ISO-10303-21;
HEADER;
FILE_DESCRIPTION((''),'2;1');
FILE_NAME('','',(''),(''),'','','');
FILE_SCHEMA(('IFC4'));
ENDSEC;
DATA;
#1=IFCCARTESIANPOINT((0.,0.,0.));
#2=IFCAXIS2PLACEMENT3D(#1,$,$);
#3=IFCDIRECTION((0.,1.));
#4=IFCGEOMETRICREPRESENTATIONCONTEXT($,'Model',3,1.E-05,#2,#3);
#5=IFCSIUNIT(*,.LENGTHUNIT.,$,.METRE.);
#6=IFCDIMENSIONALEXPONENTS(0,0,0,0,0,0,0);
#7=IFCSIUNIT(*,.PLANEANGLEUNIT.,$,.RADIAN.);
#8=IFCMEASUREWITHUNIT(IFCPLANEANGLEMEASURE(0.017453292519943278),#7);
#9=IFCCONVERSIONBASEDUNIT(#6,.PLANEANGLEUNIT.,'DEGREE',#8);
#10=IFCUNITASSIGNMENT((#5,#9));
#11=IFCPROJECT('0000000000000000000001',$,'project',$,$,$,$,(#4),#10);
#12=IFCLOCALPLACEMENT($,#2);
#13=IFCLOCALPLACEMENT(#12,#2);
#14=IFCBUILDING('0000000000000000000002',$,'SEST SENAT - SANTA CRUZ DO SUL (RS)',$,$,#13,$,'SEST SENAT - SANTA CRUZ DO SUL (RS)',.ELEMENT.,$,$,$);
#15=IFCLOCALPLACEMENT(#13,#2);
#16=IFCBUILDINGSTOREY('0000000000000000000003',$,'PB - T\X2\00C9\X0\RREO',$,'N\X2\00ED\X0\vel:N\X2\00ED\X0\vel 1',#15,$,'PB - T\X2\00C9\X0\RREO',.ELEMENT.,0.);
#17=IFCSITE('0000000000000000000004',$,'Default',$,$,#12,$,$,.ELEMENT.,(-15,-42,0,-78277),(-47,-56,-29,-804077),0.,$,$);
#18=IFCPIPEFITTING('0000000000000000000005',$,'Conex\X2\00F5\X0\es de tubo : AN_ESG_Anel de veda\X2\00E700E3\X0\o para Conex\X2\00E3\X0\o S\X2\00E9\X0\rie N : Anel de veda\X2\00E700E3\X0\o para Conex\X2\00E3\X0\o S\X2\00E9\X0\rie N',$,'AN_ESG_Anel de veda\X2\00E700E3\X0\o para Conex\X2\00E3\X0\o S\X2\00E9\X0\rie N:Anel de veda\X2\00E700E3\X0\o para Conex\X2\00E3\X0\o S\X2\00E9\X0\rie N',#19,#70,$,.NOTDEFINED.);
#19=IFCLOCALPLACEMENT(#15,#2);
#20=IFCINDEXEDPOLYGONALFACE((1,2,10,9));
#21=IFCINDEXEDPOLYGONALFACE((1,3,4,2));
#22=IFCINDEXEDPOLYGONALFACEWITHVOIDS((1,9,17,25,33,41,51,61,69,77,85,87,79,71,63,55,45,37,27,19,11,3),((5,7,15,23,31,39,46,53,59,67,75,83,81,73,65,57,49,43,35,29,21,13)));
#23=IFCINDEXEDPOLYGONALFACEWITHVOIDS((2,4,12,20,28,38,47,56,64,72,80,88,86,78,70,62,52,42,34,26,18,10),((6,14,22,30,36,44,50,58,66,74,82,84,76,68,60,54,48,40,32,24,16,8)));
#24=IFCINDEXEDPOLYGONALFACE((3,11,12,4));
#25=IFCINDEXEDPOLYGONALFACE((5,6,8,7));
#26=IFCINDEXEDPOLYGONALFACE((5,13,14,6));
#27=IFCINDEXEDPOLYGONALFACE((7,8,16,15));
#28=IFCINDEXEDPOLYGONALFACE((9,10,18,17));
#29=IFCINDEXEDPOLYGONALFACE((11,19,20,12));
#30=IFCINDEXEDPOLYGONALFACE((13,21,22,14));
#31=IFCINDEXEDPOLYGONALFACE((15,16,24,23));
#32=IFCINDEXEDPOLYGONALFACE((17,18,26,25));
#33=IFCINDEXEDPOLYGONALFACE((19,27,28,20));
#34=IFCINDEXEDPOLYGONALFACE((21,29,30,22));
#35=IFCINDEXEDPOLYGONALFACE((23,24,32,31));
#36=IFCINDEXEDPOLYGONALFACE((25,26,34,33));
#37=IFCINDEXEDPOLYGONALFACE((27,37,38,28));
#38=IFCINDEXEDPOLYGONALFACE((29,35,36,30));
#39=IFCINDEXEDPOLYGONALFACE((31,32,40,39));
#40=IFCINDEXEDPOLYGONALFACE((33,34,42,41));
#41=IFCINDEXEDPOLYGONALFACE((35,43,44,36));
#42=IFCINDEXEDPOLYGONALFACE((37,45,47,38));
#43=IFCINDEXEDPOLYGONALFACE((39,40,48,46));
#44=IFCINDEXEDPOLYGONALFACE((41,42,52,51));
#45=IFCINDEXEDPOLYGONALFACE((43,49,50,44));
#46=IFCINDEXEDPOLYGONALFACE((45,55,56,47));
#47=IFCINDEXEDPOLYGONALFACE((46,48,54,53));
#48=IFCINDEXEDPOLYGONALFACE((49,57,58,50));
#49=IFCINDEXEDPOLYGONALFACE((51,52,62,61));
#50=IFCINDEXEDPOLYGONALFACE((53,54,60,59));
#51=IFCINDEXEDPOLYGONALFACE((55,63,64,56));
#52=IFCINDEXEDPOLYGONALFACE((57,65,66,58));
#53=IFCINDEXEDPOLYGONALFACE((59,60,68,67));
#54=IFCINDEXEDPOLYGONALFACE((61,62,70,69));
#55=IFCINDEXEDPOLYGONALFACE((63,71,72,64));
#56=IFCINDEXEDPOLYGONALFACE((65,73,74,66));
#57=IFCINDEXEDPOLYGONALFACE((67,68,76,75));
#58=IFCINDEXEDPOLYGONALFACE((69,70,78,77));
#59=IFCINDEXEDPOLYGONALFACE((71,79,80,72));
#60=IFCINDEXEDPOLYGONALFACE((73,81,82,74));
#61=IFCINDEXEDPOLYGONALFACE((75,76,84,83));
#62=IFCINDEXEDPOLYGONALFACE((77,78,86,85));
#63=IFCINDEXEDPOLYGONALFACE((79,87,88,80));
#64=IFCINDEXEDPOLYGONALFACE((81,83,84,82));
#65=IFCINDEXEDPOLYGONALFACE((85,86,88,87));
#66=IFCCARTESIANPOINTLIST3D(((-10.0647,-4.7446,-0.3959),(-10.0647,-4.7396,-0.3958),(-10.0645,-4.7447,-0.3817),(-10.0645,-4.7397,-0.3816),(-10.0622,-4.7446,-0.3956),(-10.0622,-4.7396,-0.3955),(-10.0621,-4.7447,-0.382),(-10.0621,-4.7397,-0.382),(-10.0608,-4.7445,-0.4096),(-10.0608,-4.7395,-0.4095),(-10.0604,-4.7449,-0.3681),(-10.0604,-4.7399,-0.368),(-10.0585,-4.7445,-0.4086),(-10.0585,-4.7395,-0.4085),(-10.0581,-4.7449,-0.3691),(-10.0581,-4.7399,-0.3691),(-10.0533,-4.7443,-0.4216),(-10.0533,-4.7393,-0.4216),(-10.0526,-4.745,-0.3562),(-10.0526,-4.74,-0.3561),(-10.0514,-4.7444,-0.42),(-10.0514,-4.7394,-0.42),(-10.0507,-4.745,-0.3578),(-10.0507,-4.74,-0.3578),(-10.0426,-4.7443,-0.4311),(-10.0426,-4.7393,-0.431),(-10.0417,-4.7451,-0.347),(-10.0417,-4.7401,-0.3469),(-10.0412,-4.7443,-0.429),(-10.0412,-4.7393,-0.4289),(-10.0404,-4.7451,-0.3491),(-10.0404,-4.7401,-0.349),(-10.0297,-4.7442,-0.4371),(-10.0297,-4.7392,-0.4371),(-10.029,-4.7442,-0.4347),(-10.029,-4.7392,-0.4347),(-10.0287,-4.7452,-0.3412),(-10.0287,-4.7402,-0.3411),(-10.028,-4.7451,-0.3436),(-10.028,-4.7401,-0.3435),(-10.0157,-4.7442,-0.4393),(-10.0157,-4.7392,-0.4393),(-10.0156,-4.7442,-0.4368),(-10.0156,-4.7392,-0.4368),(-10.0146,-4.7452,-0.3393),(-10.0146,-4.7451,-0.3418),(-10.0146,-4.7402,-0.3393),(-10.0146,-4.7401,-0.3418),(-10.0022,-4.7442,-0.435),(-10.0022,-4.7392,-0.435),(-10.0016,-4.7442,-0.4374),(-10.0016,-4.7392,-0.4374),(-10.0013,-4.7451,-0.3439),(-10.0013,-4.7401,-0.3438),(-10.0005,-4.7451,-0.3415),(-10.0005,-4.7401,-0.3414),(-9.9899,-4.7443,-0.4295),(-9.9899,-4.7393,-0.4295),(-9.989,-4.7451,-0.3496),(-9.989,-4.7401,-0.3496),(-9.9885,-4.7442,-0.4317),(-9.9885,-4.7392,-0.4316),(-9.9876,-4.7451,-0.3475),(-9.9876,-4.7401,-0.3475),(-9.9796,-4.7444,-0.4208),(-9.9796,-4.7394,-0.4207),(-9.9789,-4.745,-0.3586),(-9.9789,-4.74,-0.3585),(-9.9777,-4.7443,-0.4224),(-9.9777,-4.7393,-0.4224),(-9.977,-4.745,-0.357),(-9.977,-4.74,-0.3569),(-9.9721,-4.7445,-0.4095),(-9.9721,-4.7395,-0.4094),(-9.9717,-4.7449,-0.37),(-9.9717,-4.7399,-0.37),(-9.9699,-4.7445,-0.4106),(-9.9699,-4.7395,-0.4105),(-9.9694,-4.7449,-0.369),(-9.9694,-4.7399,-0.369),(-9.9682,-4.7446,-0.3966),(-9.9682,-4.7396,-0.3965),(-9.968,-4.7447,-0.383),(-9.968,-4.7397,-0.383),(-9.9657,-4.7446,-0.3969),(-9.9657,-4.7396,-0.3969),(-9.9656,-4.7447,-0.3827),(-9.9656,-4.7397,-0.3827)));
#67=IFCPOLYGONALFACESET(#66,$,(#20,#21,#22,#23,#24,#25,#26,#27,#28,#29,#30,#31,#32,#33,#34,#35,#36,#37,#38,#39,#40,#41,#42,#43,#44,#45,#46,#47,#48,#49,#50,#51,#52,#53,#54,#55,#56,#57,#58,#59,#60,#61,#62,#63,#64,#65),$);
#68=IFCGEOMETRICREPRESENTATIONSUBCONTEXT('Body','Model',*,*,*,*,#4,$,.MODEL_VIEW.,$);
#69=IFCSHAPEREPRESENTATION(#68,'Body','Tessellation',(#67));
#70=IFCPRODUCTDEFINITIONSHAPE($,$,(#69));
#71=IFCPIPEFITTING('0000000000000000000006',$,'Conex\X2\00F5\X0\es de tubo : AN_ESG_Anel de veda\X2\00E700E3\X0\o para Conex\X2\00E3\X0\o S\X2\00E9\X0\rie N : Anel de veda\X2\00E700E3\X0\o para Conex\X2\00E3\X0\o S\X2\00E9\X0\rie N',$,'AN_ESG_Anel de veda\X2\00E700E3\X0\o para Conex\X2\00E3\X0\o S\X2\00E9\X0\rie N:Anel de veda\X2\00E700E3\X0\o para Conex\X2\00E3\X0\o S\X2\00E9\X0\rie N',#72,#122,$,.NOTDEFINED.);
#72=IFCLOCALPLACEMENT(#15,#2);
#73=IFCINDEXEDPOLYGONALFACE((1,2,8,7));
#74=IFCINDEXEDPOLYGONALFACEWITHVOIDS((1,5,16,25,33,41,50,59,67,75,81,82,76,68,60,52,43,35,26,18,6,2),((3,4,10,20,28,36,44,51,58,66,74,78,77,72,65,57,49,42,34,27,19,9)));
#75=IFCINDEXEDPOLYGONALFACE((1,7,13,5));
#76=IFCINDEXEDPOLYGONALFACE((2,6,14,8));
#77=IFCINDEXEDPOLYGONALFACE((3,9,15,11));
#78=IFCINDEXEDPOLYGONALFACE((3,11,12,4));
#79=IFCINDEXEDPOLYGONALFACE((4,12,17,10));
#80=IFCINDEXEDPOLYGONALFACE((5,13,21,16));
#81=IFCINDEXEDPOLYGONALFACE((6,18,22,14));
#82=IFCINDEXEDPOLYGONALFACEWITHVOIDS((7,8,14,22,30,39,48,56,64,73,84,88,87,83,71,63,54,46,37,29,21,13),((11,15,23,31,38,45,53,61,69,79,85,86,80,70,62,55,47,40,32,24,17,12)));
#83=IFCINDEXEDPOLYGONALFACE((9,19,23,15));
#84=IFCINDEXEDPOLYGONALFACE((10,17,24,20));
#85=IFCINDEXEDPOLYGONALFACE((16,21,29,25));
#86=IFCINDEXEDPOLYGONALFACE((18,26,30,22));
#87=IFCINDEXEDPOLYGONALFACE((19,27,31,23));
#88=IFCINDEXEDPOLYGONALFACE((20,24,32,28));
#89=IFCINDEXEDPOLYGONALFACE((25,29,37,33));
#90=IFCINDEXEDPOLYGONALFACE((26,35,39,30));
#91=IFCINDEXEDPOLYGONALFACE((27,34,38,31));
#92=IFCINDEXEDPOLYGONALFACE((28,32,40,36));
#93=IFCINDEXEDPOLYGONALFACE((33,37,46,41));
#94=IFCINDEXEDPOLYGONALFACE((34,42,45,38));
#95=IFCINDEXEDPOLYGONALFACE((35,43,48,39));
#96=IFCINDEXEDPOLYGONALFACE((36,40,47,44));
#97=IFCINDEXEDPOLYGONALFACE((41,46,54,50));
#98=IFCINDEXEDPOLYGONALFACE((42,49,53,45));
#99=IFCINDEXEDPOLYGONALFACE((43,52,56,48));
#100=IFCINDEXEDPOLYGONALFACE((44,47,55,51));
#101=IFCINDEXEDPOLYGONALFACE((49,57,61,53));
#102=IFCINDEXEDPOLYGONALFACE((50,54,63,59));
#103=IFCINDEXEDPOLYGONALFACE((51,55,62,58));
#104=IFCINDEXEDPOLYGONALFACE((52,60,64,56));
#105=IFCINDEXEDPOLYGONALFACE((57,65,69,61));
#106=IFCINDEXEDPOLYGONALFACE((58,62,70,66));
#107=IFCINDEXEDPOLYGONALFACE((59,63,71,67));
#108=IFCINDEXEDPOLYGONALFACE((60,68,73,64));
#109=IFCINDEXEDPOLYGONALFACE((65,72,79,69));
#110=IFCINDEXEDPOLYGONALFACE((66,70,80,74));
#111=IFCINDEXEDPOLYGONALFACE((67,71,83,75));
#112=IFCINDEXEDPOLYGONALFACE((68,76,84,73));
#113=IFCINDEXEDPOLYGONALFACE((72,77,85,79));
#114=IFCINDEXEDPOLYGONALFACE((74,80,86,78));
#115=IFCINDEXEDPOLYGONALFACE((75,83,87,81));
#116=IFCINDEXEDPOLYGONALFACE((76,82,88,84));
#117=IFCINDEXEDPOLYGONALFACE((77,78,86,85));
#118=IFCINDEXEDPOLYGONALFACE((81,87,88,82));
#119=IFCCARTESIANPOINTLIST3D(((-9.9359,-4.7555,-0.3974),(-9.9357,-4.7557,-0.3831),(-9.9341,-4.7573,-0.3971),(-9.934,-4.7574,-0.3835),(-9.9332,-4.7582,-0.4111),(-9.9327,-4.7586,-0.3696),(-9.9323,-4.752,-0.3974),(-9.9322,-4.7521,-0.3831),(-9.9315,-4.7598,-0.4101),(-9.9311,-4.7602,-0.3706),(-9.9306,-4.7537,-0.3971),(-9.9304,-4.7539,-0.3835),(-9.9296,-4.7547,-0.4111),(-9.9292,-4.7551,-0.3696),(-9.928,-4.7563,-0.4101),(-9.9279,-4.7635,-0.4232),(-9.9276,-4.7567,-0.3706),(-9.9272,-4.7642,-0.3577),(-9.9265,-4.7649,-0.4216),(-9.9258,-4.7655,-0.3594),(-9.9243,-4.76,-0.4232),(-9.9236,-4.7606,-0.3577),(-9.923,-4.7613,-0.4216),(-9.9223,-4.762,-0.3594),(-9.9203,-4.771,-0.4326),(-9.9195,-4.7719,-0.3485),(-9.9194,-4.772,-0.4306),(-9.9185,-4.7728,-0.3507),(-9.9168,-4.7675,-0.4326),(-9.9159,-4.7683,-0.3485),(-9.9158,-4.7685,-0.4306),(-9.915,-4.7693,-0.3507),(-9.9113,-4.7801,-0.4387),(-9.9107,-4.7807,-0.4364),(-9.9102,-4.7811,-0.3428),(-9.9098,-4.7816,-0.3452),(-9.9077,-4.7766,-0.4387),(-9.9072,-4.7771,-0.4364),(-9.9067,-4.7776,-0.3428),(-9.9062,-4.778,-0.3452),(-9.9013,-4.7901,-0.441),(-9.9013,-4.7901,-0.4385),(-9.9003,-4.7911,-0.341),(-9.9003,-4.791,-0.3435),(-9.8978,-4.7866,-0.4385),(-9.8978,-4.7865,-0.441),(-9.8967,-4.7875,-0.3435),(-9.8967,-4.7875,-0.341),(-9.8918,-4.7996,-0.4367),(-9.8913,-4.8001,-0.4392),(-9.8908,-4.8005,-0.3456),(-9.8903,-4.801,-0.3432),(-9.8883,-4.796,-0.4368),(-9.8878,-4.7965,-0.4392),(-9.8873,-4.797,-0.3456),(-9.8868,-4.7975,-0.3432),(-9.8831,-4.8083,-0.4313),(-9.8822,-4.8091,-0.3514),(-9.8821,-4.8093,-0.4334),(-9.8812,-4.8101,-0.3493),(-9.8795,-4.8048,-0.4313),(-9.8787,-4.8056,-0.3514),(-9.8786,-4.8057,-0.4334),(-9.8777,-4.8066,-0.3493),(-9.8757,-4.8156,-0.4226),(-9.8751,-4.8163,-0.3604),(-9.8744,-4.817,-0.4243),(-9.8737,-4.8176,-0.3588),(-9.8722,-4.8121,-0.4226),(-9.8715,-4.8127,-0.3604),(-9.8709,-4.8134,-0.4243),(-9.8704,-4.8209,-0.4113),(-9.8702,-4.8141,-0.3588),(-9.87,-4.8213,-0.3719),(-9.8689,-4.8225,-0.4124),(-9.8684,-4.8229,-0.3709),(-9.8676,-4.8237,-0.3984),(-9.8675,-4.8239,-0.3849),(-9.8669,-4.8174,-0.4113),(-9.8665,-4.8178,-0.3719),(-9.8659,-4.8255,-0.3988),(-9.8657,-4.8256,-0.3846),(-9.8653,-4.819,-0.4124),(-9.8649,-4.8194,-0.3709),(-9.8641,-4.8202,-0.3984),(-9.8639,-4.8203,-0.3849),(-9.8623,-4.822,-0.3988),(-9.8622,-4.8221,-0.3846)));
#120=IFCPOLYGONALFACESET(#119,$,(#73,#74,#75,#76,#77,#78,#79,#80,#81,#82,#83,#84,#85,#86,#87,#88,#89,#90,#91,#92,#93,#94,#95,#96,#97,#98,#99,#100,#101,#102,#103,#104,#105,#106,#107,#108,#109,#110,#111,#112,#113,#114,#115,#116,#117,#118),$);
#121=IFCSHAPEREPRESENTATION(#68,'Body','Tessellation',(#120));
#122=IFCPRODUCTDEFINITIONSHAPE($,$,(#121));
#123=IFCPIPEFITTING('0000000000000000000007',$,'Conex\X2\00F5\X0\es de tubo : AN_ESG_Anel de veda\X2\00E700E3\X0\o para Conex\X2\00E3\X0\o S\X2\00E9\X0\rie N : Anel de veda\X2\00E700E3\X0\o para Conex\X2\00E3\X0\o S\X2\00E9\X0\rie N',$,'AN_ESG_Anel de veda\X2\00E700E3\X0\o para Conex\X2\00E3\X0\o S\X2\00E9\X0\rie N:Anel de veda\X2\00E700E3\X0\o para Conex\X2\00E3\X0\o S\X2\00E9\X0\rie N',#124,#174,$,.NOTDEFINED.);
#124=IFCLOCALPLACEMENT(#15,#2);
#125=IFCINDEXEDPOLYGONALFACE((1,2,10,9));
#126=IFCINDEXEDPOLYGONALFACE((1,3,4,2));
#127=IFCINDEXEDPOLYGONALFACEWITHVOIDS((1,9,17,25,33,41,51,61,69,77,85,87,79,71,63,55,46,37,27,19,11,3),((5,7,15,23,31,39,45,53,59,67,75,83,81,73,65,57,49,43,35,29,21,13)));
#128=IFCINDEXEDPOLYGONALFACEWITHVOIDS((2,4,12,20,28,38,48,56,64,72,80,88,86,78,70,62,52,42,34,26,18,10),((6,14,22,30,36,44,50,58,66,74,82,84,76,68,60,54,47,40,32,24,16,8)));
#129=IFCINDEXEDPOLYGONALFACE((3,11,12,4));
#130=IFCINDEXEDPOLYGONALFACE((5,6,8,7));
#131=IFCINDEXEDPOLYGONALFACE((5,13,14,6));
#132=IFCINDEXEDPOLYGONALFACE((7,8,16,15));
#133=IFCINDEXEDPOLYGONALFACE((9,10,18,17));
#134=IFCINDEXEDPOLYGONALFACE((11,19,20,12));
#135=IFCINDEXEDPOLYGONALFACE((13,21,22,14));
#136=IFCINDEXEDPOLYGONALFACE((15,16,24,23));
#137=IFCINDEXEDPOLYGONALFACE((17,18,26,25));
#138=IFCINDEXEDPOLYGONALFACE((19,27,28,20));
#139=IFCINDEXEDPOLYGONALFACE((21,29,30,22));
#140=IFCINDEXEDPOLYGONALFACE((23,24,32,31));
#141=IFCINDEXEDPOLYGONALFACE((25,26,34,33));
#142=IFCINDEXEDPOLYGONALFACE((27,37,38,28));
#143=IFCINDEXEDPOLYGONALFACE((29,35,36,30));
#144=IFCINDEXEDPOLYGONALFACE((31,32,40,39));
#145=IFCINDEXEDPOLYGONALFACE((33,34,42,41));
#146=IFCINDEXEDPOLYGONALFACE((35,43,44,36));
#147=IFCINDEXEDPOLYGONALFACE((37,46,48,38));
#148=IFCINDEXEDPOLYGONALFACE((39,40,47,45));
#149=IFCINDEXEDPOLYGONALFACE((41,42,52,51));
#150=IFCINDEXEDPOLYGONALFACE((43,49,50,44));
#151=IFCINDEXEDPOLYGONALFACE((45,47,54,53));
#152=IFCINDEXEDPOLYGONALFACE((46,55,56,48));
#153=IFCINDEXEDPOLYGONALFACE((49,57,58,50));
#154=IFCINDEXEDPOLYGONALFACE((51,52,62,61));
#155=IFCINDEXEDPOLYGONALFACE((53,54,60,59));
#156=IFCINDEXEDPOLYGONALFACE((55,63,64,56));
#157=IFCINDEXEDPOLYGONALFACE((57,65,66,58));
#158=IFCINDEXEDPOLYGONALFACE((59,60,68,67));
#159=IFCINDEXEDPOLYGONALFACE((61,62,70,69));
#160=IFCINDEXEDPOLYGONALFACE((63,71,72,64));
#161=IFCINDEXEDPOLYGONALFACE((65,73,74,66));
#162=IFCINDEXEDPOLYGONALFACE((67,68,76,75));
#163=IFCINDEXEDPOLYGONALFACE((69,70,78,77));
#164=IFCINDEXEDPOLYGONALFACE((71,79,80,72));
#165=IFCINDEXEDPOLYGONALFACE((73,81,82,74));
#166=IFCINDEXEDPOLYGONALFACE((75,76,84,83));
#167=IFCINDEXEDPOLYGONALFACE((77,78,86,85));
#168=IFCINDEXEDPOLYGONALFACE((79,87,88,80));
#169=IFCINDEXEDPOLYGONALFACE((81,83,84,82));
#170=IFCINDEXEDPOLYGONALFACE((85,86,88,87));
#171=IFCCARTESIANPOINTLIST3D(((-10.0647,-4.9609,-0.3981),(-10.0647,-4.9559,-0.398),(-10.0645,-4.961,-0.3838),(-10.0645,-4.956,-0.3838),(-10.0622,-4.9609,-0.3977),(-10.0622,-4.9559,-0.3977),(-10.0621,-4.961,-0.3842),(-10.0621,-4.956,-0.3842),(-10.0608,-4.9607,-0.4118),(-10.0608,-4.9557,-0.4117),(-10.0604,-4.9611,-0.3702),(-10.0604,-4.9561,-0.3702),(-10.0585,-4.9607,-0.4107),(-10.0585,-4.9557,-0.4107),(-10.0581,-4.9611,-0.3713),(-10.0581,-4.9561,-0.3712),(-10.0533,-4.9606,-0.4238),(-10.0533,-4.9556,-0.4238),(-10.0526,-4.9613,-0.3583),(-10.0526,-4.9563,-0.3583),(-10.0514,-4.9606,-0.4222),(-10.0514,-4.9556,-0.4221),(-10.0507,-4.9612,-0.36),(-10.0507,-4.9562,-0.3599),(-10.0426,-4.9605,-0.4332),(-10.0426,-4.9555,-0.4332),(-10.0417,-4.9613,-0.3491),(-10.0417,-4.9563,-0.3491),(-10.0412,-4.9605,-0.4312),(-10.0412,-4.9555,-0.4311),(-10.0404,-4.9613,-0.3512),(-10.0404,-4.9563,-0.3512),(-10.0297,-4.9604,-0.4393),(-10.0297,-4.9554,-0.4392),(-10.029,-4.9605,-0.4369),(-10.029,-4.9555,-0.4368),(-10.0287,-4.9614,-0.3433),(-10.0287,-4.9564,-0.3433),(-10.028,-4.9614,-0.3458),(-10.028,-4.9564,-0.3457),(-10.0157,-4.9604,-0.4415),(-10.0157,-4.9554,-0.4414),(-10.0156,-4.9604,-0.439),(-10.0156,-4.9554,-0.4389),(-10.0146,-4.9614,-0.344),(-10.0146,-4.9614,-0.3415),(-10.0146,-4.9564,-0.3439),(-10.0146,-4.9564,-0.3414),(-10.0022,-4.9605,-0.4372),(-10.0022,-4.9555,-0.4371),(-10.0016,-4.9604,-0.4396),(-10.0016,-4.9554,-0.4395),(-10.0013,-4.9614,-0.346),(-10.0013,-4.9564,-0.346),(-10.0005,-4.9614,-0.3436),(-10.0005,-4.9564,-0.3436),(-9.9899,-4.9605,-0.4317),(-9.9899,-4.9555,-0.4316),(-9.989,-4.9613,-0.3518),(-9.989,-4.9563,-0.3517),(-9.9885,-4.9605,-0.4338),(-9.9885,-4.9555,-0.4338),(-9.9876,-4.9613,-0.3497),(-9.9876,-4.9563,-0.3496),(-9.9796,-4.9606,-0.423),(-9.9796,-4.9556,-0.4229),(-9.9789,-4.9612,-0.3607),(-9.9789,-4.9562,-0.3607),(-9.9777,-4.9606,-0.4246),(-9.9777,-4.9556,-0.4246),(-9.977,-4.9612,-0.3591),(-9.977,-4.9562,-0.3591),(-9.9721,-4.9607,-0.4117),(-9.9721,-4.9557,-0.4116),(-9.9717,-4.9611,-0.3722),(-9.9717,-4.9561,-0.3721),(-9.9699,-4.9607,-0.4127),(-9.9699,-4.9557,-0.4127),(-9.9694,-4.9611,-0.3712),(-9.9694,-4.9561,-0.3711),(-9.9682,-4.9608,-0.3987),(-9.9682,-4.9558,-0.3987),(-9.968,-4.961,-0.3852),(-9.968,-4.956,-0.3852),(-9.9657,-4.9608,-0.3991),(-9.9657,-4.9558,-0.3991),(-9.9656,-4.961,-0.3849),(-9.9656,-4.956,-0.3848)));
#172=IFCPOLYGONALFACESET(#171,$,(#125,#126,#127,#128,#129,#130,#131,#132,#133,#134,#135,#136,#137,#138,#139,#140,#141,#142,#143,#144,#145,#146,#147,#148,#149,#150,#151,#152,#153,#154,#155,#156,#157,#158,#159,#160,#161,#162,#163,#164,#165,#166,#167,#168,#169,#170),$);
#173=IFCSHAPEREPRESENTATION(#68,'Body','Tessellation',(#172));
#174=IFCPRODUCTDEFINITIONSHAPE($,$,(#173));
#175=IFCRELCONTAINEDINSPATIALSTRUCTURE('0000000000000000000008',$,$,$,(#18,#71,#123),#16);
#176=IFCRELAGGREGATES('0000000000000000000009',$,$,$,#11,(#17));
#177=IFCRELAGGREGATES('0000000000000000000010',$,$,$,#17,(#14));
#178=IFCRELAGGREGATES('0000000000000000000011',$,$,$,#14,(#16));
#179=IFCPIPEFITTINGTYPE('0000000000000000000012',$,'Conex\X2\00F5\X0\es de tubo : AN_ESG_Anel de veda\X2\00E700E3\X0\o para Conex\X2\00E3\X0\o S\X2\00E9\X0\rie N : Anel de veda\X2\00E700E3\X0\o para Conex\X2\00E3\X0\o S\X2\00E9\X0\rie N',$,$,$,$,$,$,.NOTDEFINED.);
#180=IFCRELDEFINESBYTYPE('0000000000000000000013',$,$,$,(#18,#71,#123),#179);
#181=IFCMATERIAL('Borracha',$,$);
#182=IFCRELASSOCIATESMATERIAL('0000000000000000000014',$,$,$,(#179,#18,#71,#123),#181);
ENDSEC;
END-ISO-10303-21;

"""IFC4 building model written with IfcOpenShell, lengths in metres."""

from ifc_helpers import new_model, entity, si_unit, converted_unit, direction, frame, origin, place, context, subcontext, project, spatial, arc, indexed_curve, outline, extrude, source, transform, mapped, material, type_object, type_shapes, element, save


model = new_model("IFC4")

# Units and contexts
model_context = context("Model", 3, precision=1e-05, world=origin(), true_north=direction((0.0, 1.0)))
body_context = subcontext(model_context, "Body", "Model", "MODEL_VIEW")
ifc_project = project(units=[si_unit("LENGTHUNIT", "METRE"), converted_unit("PLANEANGLEUNIT", "DEGREE", entity("IfcPlaneAngleMeasure", 0.017453292519943278), si_unit("PLANEANGLEUNIT", "RADIAN"), dimensions=[0, 0, 0, 0, 0, 0, 0])], contexts=[model_context])

# Site, building, storey
site_placement = place(None, origin())
site = spatial("IfcSite", under=ifc_project, at=site_placement, Name="Default", CompositionType="ELEMENT", RefLatitude=(-15, -42, 0, -78277), RefLongitude=(-47, -56, -29, -804077), RefElevation=0.0)
building_placement = place(site_placement, origin())
building = spatial("IfcBuilding", under=site, at=building_placement, Name="SEST SENAT - SANTA CRUZ DO SUL (RS)", LongName="SEST SENAT - SANTA CRUZ DO SUL (RS)", CompositionType="ELEMENT")
storey_placement = place(building_placement, origin())
storey = spatial("IfcBuildingStorey", under=building, at=storey_placement, Name="PB - TÉRREO", ObjectType="Nível:Nível 1", LongName="PB - TÉRREO", CompositionType="ELEMENT", Elevation=0.0)

# Pipe fittings
ifc_material_1 = material(Name="Borracha")
pipe_fitting_type_1 = type_object("IfcPipeFittingType", Name="Conexões de tubo : AN_ESG_Anel de vedação para Conexão Série N : Anel de vedação para Conexão Série N", PredefinedType="NOTDEFINED", material=ifc_material_1)
shared_shape_1 = source(origin(), body_context, "Body", "SweptSolid", [
    extrude(outline(indexed_curve([(-0.05, 0.0), (0.0, -0.05), (0.05, 0.0), (0.0, 0.05)], segments=[arc(1, 2, 3), arc(3, 4, 1)], self_intersect=False), holes=[indexed_curve([(-0.0475, 0.0), (0.0, 0.0475), (0.0475, 0.0), (0.0, -0.0475)], segments=[arc(1, 2, 3), arc(3, 4, 1)], self_intersect=False)]), frame((0.0, 0.0, -0.005)), (0.0, 0.0, 1.0), 0.005),
])
type_shapes(pipe_fitting_type_1, [shared_shape_1])
for number, where, z_axis, x_axis, name in (
    (1, (-10.0151, -4.7447, -0.3893), (0.0, -0.99995, -0.01), (0.01065, -0.009999, 0.999893), "Conexões de tubo : AN_ESG_Anel de vedação para Conexão Série N : Anel de vedação para Conexão Série N"),
    (2, (-9.9008, -4.7906, -0.391), (-0.707107, -0.707107, 0.000461), (0.01065, -0.009999, 0.999893), "Conexões de tubo : AN_ESG_Anel de vedação para Conexão Série N : Anel de vedação para Conexão Série N"),
    (3, (-10.0151, -4.9559, -0.3914), (0.0, 0.99995, 0.01), (0.01065, -0.009999, 0.999893), "Conexões de tubo : AN_ESG_Anel de vedação para Conexão Série N : Anel de vedação para Conexão Série N"),
):
    element("IfcPipeFitting", number, at=place(storey_placement, frame(where, z_axis=z_axis, x_axis=x_axis)), inside=storey, type_object=pipe_fitting_type_1, material=ifc_material_1, Name=name, ObjectType="AN_ESG_Anel de vedação para Conexão Série N:Anel de vedação para Conexão Série N", PredefinedType="NOTDEFINED", context=body_context, shape_type="MappedRepresentation", body=[
        mapped(shared_shape_1, transform((0.0, 0.0, 0.0), scale=1.0)),
    ])

save(model, "model.ifc")
